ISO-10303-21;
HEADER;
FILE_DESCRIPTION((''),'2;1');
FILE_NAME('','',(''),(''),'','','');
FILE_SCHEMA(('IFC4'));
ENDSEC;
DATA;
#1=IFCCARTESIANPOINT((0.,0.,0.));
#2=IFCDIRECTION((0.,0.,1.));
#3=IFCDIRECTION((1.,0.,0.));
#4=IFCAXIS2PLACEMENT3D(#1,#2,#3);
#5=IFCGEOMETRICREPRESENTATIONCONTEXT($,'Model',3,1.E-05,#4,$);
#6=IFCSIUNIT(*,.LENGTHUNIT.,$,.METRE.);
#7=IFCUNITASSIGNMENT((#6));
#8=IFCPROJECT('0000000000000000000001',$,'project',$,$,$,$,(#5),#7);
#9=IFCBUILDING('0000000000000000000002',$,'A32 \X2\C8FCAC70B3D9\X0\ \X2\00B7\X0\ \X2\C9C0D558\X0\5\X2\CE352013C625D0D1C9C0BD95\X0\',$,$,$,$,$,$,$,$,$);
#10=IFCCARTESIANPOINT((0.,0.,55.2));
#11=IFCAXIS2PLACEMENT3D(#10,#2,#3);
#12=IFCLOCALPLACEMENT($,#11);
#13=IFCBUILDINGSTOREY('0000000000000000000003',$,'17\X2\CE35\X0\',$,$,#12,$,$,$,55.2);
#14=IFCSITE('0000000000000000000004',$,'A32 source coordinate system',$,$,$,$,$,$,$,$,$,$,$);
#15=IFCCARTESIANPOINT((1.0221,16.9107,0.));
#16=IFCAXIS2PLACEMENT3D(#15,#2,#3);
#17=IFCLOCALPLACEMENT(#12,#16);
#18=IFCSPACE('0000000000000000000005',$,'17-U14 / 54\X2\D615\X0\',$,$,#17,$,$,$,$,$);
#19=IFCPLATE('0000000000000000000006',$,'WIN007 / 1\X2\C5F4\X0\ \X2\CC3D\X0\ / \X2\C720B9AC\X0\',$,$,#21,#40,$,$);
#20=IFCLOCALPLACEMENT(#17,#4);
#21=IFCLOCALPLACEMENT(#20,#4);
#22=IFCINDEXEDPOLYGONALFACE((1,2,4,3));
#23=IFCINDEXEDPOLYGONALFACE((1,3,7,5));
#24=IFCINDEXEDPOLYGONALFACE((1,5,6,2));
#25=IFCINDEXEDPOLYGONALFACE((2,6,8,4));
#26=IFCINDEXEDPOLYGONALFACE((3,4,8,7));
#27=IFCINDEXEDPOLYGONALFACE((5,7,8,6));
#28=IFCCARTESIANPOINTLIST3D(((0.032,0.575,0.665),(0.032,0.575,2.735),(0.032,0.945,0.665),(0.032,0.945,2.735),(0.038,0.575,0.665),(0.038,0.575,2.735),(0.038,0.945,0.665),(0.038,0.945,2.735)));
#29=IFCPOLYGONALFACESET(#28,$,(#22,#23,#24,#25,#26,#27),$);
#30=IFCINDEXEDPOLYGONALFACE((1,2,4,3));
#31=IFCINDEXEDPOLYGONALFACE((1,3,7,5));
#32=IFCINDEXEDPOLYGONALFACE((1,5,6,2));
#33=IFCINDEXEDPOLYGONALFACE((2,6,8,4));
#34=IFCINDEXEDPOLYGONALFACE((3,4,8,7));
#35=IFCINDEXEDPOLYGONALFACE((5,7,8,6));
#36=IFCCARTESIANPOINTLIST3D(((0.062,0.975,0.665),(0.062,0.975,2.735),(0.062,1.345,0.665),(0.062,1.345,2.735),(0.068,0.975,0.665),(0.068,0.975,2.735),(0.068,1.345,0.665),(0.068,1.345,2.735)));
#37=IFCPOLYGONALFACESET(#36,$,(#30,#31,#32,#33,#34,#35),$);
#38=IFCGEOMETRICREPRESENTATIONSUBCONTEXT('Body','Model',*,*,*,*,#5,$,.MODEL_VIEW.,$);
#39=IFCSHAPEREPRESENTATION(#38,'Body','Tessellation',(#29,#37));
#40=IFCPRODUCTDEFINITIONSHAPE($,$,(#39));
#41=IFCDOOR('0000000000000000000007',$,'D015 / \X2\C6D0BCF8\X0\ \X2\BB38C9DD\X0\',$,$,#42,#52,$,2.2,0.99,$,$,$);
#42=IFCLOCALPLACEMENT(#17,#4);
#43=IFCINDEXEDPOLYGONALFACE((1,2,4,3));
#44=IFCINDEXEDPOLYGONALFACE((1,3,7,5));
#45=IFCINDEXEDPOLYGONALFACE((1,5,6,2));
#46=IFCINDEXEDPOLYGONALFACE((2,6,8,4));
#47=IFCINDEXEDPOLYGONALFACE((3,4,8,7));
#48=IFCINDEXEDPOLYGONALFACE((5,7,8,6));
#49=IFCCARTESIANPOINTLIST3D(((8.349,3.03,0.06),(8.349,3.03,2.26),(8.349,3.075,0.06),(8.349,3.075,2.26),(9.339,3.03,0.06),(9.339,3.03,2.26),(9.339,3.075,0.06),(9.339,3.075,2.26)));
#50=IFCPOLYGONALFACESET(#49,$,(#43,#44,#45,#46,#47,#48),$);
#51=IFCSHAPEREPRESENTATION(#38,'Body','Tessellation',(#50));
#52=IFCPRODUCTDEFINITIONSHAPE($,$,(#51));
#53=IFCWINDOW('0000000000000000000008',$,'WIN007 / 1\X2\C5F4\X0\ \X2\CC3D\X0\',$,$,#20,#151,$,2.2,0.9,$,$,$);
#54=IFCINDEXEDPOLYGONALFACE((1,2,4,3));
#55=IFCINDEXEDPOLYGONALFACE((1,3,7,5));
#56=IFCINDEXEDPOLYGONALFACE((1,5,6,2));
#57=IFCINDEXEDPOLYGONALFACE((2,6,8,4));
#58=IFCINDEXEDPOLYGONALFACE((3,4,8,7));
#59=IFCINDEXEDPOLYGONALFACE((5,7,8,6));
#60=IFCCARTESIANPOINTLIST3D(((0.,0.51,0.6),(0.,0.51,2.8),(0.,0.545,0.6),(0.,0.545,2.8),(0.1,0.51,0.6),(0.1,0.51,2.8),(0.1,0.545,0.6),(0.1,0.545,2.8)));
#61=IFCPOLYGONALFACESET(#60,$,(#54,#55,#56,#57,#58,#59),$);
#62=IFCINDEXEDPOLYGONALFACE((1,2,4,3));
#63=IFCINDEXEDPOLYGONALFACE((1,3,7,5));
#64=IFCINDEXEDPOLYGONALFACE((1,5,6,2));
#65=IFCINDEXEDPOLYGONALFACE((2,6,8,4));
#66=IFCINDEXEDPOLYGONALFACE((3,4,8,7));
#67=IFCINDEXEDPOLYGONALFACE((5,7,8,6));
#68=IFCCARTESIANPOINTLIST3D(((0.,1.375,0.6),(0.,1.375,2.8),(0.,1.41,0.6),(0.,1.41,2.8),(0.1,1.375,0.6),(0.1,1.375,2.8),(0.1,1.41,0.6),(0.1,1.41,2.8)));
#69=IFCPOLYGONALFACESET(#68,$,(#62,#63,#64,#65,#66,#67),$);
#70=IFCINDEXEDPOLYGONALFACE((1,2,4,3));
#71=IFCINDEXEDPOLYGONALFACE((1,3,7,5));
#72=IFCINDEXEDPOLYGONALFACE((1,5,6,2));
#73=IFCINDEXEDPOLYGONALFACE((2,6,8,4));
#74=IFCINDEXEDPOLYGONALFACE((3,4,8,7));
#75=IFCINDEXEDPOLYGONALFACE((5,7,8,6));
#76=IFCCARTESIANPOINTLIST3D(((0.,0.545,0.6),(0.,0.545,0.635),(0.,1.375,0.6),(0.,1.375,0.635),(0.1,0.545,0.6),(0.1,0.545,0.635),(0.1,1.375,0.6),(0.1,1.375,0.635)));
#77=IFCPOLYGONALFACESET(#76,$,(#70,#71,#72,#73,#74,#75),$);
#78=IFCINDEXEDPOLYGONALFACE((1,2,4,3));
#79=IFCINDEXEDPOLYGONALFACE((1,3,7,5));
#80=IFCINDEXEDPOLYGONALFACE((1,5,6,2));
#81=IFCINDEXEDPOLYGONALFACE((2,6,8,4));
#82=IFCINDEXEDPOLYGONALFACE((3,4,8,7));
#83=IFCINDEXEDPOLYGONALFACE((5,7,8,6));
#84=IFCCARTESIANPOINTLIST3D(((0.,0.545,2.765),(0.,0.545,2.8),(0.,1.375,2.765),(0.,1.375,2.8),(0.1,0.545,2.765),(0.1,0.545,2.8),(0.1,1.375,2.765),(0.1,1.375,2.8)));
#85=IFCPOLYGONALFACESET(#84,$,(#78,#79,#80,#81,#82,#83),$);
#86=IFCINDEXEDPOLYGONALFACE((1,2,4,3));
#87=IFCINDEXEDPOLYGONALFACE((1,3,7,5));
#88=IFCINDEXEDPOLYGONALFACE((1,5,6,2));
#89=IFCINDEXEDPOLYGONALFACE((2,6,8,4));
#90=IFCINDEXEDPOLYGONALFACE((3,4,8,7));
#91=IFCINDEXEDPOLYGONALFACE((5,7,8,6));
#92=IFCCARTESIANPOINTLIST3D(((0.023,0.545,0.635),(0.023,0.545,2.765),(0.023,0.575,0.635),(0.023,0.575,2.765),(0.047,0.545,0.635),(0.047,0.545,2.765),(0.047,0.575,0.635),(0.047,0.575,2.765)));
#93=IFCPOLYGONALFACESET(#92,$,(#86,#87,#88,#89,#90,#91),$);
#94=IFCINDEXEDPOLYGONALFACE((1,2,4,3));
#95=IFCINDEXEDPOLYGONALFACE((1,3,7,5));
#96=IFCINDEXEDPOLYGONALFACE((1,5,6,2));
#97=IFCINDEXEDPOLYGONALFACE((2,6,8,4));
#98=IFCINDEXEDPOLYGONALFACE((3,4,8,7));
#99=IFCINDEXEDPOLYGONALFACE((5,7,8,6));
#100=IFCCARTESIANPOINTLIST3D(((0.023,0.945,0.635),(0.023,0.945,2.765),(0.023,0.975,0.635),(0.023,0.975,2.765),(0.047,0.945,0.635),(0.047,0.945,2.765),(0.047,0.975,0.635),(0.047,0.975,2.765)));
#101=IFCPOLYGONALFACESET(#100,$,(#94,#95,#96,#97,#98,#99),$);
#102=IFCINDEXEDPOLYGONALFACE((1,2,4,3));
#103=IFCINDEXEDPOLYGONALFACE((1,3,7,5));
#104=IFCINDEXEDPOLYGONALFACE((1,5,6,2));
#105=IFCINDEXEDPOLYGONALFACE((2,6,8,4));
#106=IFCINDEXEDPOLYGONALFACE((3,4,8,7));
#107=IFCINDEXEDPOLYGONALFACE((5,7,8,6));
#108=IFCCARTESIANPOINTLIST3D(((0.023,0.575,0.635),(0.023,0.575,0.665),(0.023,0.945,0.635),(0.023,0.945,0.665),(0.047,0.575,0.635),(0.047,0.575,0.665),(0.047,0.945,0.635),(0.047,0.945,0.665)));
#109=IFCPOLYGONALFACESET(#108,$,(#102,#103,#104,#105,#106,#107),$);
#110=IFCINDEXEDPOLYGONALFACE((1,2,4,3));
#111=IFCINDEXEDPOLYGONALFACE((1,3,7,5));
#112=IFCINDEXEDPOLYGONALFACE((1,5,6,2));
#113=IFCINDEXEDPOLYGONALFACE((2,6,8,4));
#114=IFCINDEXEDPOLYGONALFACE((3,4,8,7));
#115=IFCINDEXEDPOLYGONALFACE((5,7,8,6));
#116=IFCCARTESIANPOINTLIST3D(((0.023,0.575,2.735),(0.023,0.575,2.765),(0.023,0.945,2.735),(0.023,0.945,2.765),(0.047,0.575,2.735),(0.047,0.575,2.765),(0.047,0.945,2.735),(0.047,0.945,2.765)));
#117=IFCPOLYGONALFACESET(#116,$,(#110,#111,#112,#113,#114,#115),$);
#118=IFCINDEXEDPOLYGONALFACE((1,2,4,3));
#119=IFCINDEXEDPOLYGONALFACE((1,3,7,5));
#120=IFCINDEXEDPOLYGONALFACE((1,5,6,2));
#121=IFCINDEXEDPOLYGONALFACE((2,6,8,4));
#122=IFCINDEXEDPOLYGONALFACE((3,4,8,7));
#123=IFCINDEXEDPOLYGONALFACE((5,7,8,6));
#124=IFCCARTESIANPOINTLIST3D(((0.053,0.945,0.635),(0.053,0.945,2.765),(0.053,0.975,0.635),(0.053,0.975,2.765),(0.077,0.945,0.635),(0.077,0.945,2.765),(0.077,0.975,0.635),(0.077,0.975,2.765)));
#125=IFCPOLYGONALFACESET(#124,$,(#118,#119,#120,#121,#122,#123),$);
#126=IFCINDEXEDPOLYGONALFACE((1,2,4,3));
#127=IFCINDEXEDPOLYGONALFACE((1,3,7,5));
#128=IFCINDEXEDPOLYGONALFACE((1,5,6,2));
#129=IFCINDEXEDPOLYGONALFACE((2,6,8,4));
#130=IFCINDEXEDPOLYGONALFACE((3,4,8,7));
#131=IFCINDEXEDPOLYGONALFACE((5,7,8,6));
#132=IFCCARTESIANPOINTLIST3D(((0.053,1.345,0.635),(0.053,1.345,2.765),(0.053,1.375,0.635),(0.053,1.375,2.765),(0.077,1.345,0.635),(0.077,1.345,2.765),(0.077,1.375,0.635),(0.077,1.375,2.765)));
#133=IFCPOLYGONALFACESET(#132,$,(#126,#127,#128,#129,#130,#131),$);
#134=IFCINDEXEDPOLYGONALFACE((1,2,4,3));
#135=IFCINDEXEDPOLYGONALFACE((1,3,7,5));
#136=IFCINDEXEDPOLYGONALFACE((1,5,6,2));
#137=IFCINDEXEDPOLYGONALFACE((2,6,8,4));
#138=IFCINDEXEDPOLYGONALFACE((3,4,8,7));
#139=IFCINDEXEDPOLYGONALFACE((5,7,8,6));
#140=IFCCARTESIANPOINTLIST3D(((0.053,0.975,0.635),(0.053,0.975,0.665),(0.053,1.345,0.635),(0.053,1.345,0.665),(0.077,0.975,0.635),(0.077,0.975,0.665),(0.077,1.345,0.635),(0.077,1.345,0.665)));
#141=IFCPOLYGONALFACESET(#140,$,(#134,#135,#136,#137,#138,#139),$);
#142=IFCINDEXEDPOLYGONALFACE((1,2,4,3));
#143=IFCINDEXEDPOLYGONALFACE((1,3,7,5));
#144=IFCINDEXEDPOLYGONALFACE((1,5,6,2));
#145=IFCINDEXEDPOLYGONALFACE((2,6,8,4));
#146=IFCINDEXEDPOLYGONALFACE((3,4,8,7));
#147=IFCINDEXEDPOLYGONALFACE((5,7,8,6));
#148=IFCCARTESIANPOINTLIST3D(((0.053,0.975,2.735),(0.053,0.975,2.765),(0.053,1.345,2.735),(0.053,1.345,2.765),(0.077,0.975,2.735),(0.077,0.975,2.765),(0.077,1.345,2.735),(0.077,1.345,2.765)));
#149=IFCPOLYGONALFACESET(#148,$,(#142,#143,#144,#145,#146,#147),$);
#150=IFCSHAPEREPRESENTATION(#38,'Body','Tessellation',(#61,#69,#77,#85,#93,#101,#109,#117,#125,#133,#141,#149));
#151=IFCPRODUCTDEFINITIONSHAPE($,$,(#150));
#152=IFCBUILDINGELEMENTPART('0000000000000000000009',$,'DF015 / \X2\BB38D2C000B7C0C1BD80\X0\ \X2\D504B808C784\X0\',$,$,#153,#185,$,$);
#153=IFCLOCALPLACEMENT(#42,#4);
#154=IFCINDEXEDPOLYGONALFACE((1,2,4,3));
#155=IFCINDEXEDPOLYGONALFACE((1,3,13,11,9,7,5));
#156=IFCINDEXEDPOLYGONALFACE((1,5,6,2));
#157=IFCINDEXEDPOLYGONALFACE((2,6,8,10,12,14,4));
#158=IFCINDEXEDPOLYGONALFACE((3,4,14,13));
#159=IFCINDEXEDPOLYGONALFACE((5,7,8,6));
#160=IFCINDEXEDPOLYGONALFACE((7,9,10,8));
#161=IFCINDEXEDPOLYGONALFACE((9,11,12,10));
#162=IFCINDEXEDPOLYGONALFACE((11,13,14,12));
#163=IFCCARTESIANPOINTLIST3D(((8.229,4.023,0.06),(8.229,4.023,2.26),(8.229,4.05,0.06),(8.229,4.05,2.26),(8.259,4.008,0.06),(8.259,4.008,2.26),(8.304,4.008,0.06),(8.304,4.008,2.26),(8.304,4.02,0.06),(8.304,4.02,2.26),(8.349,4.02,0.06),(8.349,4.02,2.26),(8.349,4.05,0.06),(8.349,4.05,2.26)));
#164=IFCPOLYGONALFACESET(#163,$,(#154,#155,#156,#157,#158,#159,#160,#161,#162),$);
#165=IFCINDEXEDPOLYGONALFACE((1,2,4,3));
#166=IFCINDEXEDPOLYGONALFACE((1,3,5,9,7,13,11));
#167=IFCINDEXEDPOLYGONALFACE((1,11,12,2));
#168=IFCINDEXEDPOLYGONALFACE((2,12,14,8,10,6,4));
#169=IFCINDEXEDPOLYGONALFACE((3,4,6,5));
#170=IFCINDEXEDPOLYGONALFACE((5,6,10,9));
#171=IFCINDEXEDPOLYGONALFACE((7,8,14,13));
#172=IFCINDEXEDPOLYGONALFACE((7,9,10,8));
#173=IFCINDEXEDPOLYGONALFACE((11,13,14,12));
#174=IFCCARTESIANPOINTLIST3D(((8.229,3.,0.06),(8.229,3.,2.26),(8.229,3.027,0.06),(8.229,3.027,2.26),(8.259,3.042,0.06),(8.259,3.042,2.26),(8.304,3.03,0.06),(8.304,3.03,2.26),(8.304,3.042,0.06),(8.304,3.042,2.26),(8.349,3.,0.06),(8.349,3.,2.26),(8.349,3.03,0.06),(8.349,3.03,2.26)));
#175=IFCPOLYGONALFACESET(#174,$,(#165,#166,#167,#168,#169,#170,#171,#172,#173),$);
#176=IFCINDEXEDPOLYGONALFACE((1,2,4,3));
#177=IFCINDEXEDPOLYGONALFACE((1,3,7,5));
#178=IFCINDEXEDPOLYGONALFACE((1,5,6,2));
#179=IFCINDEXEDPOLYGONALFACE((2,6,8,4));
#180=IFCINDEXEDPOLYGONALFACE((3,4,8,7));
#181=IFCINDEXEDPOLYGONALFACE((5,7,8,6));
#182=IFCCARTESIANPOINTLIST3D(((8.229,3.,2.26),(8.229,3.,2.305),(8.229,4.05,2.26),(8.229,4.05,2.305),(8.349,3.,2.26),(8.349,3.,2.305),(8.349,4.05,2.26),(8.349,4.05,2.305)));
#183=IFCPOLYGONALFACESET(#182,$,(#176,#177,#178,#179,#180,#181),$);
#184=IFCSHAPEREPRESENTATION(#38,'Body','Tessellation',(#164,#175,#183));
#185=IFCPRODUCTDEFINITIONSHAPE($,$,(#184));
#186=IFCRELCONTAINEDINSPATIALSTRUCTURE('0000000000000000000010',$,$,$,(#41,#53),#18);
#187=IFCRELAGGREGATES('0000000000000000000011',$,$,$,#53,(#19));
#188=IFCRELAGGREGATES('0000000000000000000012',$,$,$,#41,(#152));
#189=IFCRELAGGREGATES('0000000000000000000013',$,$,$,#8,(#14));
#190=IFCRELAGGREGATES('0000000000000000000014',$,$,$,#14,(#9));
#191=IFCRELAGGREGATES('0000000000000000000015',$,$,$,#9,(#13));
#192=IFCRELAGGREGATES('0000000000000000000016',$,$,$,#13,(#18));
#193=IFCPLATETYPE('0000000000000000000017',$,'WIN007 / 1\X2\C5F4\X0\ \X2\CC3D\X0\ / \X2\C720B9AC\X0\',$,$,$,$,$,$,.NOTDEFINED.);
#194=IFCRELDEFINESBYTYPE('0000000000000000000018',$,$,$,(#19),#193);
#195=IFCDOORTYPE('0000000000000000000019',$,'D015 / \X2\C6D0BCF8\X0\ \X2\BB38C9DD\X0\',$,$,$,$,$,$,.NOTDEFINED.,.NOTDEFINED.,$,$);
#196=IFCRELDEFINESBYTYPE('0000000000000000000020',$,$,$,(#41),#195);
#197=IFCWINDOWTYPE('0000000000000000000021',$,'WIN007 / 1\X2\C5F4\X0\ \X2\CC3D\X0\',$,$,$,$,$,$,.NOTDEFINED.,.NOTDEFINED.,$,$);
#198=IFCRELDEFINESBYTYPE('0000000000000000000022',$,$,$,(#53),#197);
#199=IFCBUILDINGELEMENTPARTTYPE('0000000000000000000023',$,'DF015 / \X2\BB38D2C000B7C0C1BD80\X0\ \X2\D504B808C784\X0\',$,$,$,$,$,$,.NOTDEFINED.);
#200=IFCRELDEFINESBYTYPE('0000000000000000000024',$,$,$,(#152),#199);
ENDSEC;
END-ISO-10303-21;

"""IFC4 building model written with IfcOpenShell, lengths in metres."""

from ifc_helpers import new_model, si_unit, frame, origin, origin_with_axes, place, context, subcontext, project, spatial, polyline, outline, extrude, source, transform, mapped, type_object, type_shapes, element, aggregate, save


model = new_model("IFC4")

# Units and contexts
model_context = context("Model", 3, precision=1e-05, world=origin_with_axes())
body_context = subcontext(model_context, "Body", "Model", "MODEL_VIEW")
ifc_project = project(units=[si_unit("LENGTHUNIT", "METRE")], contexts=[model_context])

# Plate
plate_type_1 = type_object("IfcPlateType", Name="WIN007 / 1열 창 / 유리", PredefinedType="NOTDEFINED")
shared_shape_1 = source(origin(), body_context, "Body", "SweptSolid", [
    extrude(outline(polyline([(0.032, 0.575), (0.032, 0.945), (0.038, 0.945), (0.038, 0.575), (0.032, 0.575)])), frame((0.0, 0.0, 0.665)), (0.0, 0.0, 1.0), 2.07),
    extrude(outline(polyline([(0.062, 0.975), (0.062, 1.345), (0.068, 1.345), (0.068, 0.975), (0.062, 0.975)])), frame((0.0, 0.0, 0.665)), (0.0, 0.0, 1.0), 2.07),
])
type_shapes(plate_type_1, [shared_shape_1])
storey_placement = place(None, frame((0.0, 0.0, 55.2), z_axis=(0.0, 0.0, 1.0), x_axis=(1.0, 0.0, 0.0)))
space_1_placement = place(storey_placement, frame((1.0221, 16.9107, 0.0), z_axis=(0.0, 0.0, 1.0), x_axis=(1.0, 0.0, 0.0)))
window_1_placement = place(space_1_placement, origin_with_axes())
plate_1_placement = place(window_1_placement, origin_with_axes())
plate_1 = element("IfcPlate", 1, at=plate_1_placement, type_object=plate_type_1, Name="WIN007 / 1열 창 / 유리", context=body_context, shape_type="MappedRepresentation", body=[
    mapped(shared_shape_1, transform((0.0, 0.0, 0.0), scale=1.0)),
])

# Site, building, storey, space
site = spatial("IfcSite", under=ifc_project, Name="A32 source coordinate system")
building = spatial("IfcBuilding", under=site, Name="A32 주거동 · 지하5층–옥탑지붕")
storey = spatial("IfcBuildingStorey", under=building, at=storey_placement, Name="17층", Elevation=55.2)
space_1 = spatial("IfcSpace", under=storey, at=space_1_placement, Name="17-U14 / 54형")

# Door
door_type_1 = type_object("IfcDoorType", Name="D015 / 원본 문짝", OperationType="NOTDEFINED", PredefinedType="NOTDEFINED")
shared_shape_2 = source(origin(), body_context, "Body", "SweptSolid", [
    extrude(outline(polyline([(9.339, 3.075), (9.339, 3.03), (8.349, 3.03), (8.349, 3.075), (9.339, 3.075)])), frame((0.0, 0.0, 0.06)), (0.0, 0.0, 1.0), 2.2),
])
type_shapes(door_type_1, [shared_shape_2])
door_1_placement = place(space_1_placement, origin_with_axes())
door_1 = element("IfcDoor", 2, at=door_1_placement, inside=space_1, type_object=door_type_1, Name="D015 / 원본 문짝", OverallHeight=2.2, OverallWidth=0.99, context=body_context, shape_type="MappedRepresentation", body=[
    mapped(shared_shape_2, transform((0.0, 0.0, 0.0), scale=1.0)),
])

# Window
window_type_1 = type_object("IfcWindowType", Name="WIN007 / 1열 창", PartitioningType="NOTDEFINED", PredefinedType="NOTDEFINED")
shared_shape_3 = source(origin(), body_context, "Body", "SweptSolid", [
    extrude(outline(polyline([(0.0, 0.51), (0.0, 0.545), (0.1, 0.545), (0.1, 0.51), (0.0, 0.51)])), frame((0.0, 0.0, 0.6)), (0.0, 0.0, 1.0), 2.2),
    extrude(outline(polyline([(0.0, 1.375), (0.0, 1.41), (0.1, 1.41), (0.1, 1.375), (0.0, 1.375)])), frame((0.0, 0.0, 0.6)), (0.0, 0.0, 1.0), 2.2),
    extrude(outline(polyline([(0.0, 0.545), (0.0, 1.375), (0.1, 1.375), (0.1, 0.545), (0.0, 0.545)])), frame((0.0, 0.0, 0.6)), (0.0, 0.0, 1.0), 0.035),
    extrude(outline(polyline([(0.0, 0.545), (0.0, 1.375), (0.1, 1.375), (0.1, 0.545), (0.0, 0.545)])), frame((0.0, 0.0, 2.765)), (0.0, 0.0, 1.0), 0.035),
    extrude(outline(polyline([(0.023, 0.545), (0.023, 0.575), (0.047, 0.575), (0.047, 0.545), (0.023, 0.545)])), frame((0.0, 0.0, 0.635)), (0.0, 0.0, 1.0), 2.13),
    extrude(outline(polyline([(0.023, 0.945), (0.023, 0.975), (0.047, 0.975), (0.047, 0.945), (0.023, 0.945)])), frame((0.0, 0.0, 0.635)), (0.0, 0.0, 1.0), 2.13),
    extrude(outline(polyline([(0.023, 0.575), (0.023, 0.945), (0.047, 0.945), (0.047, 0.575), (0.023, 0.575)])), frame((0.0, 0.0, 0.635)), (0.0, 0.0, 1.0), 0.03),
    extrude(outline(polyline([(0.023, 0.575), (0.023, 0.945), (0.047, 0.945), (0.047, 0.575), (0.023, 0.575)])), frame((0.0, 0.0, 2.735)), (0.0, 0.0, 1.0), 0.03),
    extrude(outline(polyline([(0.053, 0.945), (0.053, 0.975), (0.077, 0.975), (0.077, 0.945), (0.053, 0.945)])), frame((0.0, 0.0, 0.635)), (0.0, 0.0, 1.0), 2.13),
    extrude(outline(polyline([(0.053, 1.345), (0.053, 1.375), (0.077, 1.375), (0.077, 1.345), (0.053, 1.345)])), frame((0.0, 0.0, 0.635)), (0.0, 0.0, 1.0), 2.13),
    extrude(outline(polyline([(0.053, 0.975), (0.053, 1.345), (0.077, 1.345), (0.077, 0.975), (0.053, 0.975)])), frame((0.0, 0.0, 0.635)), (0.0, 0.0, 1.0), 0.03),
    extrude(outline(polyline([(0.053, 0.975), (0.053, 1.345), (0.077, 1.345), (0.077, 0.975), (0.053, 0.975)])), frame((0.0, 0.0, 2.735)), (0.0, 0.0, 1.0), 0.03),
])
type_shapes(window_type_1, [shared_shape_3])
window_1 = element("IfcWindow", 3, at=window_1_placement, inside=space_1, type_object=window_type_1, Name="WIN007 / 1열 창", OverallHeight=2.2, OverallWidth=0.9, context=body_context, shape_type="MappedRepresentation", body=[
    mapped(shared_shape_3, transform((0.0, 0.0, 0.0), scale=1.0)),
])
aggregate(window_1, [plate_1])

# Building element part
building_element_part_type_1 = type_object("IfcBuildingElementPartType", Name="DF015 / 문틀·상부 프레임", PredefinedType="NOTDEFINED")
shared_shape_4 = source(origin(), body_context, "Body", "SweptSolid", [
    extrude(outline(polyline([(8.349, 4.02), (8.304, 4.02), (8.304, 4.008), (8.259, 4.008), (8.229, 4.023), (8.229, 4.05), (8.349, 4.05), (8.349, 4.02)])), frame((0.0, 0.0, 0.06)), (0.0, 0.0, 1.0), 2.2),
    extrude(outline(polyline([(8.229, 3.0), (8.229, 3.027), (8.259, 3.042), (8.304, 3.042), (8.304, 3.03), (8.349, 3.03), (8.349, 3.0), (8.229, 3.0)])), frame((0.0, 0.0, 0.06)), (0.0, 0.0, 1.0), 2.2),
    extrude(outline(polyline([(8.229, 3.0), (8.229, 4.05), (8.349, 4.05), (8.349, 3.0), (8.229, 3.0)])), frame((0.0, 0.0, 2.26)), (0.0, 0.0, 1.0), 0.045),
])
type_shapes(building_element_part_type_1, [shared_shape_4])
building_element_part_1_placement = place(door_1_placement, origin_with_axes())
building_element_part_1 = element("IfcBuildingElementPart", 4, at=building_element_part_1_placement, type_object=building_element_part_type_1, Name="DF015 / 문틀·상부 프레임", context=body_context, shape_type="MappedRepresentation", body=[
    mapped(shared_shape_4, transform((0.0, 0.0, 0.0), scale=1.0)),
])
aggregate(door_1, [building_element_part_1])

save(model, "model.ifc")
